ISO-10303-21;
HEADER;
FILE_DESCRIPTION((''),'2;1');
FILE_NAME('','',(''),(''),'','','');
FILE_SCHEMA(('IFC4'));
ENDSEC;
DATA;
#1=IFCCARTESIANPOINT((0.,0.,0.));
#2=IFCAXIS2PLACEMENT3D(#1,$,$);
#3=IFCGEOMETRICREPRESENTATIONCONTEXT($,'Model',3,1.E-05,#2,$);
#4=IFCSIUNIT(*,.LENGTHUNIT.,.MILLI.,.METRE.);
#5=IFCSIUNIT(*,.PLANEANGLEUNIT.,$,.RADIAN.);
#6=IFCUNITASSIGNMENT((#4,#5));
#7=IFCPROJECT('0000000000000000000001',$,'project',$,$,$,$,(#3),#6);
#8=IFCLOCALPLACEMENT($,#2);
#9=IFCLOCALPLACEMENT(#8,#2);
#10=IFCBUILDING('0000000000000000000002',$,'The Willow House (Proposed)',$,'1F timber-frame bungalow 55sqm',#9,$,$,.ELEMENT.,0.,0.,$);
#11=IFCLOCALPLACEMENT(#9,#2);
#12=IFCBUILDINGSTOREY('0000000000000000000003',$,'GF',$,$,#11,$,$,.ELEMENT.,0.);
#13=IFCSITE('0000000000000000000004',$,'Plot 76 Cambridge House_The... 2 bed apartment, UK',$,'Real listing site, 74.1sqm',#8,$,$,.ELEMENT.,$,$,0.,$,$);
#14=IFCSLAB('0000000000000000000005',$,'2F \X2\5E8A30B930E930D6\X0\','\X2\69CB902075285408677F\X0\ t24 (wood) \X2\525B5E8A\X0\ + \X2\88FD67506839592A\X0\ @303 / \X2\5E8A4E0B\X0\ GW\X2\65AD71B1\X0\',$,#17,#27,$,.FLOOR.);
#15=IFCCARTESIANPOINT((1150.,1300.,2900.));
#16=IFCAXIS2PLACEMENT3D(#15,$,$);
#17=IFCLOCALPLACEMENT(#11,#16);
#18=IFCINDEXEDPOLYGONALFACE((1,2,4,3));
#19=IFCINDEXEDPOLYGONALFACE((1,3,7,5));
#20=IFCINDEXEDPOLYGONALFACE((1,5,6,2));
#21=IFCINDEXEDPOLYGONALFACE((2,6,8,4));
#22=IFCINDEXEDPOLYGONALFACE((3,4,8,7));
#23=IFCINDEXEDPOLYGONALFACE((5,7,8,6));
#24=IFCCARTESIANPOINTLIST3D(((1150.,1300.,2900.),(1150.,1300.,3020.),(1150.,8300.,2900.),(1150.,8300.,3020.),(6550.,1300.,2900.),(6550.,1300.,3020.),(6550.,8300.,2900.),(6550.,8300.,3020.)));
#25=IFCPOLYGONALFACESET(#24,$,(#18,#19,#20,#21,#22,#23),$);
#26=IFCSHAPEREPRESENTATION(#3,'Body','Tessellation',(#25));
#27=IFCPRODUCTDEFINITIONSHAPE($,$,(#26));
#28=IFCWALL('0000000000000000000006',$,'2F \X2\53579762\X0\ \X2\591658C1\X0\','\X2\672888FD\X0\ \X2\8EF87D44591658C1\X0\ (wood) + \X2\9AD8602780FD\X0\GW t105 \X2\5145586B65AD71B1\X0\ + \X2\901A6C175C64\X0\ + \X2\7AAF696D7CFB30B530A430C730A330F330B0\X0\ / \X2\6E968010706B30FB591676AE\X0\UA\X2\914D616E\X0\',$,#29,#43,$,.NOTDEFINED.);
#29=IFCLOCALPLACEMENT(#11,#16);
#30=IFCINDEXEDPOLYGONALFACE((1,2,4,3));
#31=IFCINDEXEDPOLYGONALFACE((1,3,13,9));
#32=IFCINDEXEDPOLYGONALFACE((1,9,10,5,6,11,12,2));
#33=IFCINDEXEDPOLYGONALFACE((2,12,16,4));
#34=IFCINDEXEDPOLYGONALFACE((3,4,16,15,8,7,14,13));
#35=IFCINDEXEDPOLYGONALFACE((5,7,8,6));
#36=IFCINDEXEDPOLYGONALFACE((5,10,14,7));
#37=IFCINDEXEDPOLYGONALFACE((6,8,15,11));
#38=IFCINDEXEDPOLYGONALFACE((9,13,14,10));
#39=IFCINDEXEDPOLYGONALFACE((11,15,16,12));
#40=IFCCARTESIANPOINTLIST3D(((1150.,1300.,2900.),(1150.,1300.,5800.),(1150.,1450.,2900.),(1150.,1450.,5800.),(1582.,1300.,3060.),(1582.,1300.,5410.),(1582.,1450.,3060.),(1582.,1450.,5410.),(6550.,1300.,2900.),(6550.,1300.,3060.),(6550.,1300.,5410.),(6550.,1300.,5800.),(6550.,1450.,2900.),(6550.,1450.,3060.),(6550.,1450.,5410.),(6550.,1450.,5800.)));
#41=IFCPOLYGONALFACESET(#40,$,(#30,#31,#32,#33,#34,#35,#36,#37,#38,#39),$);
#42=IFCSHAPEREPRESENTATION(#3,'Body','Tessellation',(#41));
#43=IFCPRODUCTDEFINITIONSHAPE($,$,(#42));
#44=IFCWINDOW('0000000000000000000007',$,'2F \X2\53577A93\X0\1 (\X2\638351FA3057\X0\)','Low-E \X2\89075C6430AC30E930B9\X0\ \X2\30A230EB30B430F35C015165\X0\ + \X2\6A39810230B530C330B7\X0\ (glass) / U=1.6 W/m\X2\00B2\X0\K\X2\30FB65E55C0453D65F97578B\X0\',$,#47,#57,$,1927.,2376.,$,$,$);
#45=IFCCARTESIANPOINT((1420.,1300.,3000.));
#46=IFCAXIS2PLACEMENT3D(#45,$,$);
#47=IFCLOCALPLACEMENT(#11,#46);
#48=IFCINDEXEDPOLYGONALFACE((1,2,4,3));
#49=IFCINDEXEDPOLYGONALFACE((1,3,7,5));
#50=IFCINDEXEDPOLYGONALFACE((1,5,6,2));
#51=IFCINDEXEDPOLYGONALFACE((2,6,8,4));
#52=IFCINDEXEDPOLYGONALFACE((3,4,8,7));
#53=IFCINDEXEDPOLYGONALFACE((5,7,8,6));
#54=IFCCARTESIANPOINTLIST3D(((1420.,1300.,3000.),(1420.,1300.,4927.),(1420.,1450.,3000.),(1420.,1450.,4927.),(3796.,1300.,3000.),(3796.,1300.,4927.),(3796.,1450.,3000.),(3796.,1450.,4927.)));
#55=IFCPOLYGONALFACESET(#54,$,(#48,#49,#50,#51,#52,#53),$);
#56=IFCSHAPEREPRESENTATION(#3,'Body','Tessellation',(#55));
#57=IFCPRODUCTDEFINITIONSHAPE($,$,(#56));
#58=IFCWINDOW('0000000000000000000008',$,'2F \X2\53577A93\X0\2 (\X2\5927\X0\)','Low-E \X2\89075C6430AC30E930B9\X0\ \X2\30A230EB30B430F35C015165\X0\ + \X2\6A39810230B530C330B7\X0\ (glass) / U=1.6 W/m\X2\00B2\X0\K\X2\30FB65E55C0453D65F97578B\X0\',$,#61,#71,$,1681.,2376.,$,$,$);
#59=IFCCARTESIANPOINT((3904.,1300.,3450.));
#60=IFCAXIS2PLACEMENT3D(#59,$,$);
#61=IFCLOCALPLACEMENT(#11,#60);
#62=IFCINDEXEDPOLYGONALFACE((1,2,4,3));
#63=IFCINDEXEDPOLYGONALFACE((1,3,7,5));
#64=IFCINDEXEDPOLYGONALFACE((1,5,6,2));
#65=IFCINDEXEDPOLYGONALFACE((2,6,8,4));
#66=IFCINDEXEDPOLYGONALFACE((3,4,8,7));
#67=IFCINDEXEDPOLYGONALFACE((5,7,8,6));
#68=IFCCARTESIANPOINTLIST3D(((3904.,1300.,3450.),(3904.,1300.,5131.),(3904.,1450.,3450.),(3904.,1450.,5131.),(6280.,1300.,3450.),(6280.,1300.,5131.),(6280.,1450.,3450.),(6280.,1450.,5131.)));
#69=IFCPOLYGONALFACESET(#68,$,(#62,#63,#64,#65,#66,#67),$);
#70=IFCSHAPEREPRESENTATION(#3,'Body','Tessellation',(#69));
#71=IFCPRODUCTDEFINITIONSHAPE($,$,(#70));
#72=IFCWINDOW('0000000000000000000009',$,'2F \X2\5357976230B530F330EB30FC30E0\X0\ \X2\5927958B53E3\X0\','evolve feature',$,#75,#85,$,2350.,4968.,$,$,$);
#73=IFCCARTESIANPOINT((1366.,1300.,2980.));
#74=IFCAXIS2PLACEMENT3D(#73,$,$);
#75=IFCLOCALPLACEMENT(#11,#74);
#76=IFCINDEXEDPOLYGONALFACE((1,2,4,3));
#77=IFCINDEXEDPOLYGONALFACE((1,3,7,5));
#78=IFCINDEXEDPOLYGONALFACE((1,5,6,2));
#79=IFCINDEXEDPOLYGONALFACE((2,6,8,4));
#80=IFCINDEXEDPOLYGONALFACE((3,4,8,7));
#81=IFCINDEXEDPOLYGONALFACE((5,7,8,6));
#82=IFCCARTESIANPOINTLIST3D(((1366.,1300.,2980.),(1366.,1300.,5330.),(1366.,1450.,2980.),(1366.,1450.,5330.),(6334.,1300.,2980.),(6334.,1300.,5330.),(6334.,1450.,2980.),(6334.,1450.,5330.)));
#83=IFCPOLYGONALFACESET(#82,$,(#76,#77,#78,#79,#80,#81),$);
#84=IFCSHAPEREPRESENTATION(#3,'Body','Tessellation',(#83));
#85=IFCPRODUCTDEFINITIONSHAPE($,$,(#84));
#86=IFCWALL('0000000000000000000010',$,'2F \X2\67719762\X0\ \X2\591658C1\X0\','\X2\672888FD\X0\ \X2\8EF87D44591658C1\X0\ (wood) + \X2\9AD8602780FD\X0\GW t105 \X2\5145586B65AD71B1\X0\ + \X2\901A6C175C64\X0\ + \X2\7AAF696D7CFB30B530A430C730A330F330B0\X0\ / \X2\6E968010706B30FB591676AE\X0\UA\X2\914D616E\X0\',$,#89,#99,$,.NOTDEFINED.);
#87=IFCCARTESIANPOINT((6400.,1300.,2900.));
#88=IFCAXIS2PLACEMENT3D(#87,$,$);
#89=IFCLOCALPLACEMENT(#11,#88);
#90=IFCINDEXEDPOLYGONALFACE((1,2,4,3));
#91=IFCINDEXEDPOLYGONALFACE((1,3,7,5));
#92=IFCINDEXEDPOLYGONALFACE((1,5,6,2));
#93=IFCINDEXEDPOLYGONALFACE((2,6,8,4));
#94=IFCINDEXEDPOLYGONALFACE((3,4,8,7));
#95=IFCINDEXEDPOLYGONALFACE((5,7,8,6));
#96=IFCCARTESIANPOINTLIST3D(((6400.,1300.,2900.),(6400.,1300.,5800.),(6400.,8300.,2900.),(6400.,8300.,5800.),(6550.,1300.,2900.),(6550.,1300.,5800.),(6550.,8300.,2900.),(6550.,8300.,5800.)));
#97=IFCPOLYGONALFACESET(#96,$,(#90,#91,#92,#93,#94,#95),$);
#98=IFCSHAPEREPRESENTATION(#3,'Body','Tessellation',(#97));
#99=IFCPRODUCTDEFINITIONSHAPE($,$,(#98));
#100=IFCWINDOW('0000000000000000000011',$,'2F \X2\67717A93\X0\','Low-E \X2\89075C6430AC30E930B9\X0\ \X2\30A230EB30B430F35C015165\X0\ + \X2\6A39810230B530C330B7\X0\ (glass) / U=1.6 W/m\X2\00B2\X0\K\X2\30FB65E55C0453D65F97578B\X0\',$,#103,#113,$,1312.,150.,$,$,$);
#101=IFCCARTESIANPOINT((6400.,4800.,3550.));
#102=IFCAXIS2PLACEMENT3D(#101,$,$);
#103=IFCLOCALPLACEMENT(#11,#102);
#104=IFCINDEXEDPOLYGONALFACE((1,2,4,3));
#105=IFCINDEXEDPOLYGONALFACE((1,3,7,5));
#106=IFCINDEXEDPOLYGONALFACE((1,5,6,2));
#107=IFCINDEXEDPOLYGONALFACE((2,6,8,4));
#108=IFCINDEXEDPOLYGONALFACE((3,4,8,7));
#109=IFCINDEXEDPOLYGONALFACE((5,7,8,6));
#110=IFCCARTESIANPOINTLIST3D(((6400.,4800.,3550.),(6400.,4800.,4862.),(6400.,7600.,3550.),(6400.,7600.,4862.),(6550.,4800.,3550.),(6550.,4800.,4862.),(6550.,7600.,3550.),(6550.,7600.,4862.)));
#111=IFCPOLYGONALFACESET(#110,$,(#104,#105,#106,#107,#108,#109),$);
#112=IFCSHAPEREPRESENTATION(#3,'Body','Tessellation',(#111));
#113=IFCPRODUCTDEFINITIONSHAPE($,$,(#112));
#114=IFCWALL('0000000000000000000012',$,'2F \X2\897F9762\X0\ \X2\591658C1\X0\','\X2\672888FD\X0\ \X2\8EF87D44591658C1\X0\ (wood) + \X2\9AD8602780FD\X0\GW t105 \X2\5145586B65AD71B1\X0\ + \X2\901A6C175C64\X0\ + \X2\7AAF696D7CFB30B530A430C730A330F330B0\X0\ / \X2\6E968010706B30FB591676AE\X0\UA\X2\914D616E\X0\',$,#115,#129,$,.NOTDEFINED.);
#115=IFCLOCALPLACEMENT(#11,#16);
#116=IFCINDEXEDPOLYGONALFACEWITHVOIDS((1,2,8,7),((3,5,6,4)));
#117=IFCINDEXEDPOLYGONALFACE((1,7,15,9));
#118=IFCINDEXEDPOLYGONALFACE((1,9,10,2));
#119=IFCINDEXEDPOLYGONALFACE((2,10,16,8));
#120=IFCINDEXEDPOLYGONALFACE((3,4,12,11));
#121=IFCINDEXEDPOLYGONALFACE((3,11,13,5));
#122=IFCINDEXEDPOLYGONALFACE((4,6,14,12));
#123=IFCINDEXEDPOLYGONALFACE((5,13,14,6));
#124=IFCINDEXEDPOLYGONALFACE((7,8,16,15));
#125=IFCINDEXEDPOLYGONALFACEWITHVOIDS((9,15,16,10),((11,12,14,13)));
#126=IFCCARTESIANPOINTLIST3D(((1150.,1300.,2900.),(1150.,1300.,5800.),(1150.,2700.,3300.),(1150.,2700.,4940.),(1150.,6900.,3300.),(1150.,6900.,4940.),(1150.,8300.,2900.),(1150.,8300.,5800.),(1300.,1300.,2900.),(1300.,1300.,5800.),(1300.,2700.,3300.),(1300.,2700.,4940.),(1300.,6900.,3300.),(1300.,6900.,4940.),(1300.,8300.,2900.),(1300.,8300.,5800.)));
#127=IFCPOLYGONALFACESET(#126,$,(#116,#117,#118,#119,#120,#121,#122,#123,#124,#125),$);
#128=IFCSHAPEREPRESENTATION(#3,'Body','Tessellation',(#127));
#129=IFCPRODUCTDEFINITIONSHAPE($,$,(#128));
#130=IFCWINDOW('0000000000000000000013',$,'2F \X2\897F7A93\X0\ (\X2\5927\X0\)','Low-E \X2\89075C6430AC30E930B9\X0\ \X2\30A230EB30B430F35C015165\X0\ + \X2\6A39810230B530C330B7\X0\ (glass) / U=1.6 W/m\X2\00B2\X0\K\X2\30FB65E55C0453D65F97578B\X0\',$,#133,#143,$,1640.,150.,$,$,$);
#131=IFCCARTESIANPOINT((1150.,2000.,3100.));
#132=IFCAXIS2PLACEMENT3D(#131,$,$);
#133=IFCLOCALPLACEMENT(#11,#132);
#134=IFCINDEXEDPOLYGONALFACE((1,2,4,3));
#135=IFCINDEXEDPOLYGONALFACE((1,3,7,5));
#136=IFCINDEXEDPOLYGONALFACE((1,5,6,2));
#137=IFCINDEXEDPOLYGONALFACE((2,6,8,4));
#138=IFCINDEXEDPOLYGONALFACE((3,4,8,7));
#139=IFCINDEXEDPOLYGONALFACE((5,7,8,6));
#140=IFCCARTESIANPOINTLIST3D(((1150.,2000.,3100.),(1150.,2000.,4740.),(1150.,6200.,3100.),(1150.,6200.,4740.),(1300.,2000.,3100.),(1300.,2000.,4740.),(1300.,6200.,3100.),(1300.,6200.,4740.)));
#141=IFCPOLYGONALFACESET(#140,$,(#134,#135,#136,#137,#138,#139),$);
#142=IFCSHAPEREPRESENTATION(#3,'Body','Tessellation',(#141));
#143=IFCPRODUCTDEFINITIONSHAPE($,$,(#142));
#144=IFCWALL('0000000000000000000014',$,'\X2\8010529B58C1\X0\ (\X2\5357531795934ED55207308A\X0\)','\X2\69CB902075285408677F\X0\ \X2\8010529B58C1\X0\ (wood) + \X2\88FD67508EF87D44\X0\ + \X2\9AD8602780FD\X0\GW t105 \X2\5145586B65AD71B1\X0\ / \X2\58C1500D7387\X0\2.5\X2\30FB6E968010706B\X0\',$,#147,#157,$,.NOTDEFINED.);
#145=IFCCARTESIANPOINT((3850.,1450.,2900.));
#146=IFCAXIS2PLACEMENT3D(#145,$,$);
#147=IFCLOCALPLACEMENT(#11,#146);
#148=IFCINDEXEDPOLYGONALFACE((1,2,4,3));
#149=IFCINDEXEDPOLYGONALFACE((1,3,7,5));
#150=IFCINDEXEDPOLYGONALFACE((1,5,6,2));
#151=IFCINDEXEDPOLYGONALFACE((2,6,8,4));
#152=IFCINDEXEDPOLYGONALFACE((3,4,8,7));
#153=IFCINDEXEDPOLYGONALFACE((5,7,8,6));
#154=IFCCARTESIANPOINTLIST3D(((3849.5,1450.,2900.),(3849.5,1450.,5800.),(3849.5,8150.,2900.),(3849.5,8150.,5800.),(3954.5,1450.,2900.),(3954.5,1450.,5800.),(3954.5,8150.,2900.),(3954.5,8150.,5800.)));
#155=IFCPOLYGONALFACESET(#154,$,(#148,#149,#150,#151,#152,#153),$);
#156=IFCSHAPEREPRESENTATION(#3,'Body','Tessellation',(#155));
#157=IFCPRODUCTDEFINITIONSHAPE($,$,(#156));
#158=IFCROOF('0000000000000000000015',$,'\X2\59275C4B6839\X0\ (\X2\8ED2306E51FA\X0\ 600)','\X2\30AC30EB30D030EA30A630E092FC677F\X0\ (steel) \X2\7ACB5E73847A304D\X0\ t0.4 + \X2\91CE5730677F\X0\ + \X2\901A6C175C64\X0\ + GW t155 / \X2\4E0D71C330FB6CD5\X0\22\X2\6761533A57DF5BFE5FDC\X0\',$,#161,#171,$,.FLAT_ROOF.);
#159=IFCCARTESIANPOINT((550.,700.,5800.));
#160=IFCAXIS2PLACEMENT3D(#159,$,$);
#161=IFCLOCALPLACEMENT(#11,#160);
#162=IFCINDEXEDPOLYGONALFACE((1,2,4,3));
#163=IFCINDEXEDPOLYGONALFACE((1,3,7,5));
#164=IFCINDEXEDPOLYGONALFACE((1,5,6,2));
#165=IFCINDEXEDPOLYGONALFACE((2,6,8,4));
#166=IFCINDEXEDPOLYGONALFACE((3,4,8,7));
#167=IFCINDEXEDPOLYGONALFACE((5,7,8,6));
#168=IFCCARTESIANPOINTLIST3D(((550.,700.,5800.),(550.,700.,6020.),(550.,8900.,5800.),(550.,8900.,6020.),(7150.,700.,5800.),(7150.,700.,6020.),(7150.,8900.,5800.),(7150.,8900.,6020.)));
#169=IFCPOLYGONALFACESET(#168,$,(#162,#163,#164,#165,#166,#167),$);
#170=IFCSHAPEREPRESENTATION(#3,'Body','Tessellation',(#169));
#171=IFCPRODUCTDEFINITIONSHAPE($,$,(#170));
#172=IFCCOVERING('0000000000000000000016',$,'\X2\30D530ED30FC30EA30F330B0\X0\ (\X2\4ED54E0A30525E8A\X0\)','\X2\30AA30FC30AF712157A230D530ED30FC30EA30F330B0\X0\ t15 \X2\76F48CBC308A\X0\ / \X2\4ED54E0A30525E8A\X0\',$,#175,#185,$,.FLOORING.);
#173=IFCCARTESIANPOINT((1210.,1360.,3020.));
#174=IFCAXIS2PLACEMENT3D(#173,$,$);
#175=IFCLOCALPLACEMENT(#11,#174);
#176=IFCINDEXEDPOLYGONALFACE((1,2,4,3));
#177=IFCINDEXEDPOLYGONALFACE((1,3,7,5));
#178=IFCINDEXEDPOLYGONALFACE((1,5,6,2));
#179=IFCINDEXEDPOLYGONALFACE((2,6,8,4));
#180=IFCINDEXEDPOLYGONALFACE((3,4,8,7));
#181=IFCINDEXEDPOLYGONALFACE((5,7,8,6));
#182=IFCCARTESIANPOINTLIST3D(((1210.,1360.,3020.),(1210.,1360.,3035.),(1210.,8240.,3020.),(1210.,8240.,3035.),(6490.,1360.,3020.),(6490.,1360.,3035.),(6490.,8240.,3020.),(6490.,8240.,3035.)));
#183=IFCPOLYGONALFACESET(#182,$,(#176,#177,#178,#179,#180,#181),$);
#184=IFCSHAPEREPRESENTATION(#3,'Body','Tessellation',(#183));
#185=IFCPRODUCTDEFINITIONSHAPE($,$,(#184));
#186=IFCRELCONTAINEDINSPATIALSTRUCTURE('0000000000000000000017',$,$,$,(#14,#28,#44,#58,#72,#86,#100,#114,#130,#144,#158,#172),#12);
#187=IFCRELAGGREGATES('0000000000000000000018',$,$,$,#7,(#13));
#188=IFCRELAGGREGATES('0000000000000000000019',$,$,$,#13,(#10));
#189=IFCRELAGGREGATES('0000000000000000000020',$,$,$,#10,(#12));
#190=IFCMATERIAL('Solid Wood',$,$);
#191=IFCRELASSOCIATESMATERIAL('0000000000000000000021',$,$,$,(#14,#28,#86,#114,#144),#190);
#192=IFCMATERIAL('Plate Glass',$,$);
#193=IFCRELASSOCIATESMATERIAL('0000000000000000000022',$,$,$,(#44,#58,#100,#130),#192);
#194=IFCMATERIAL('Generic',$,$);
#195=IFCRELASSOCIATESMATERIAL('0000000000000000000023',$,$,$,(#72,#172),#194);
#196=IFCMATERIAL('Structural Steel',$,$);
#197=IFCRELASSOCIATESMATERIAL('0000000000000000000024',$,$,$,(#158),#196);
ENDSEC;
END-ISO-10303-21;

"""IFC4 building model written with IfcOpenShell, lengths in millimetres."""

from ifc_helpers import new_model, si_unit, frame, frame_2d, origin, place, context, project, spatial, rectangle, extrude, material, element, fill, save


model = new_model("IFC4")

# Units and contexts
model_context = context("Model", 3, precision=1e-05, world=origin())
ifc_project = project(units=[si_unit("LENGTHUNIT", "METRE", prefix="MILLI"), si_unit("PLANEANGLEUNIT", "RADIAN")], contexts=[model_context])

# Site, building, storey
site_placement = place(None, origin())
site = spatial("IfcSite", under=ifc_project, at=site_placement, Name="Plot 76 Cambridge House_The... 2 bed apartment, UK", ObjectType="Real listing site, 74.1sqm", CompositionType="ELEMENT", RefElevation=0.0)
building_placement = place(site_placement, origin())
building = spatial("IfcBuilding", under=site, at=building_placement, Name="The Willow House (Proposed)", ObjectType="1F timber-frame bungalow 55sqm", CompositionType="ELEMENT", ElevationOfRefHeight=0.0, ElevationOfTerrain=0.0)
storey_placement = place(building_placement, origin())
storey = spatial("IfcBuildingStorey", under=building, at=storey_placement, Name="GF", CompositionType="ELEMENT", Elevation=0.0)

# Slab
ifc_material_1 = material(Name="Solid Wood")
slab_placement = place(storey_placement, frame((1150.0, 1300.0, 2900.0)))
element("IfcSlab", 1, at=slab_placement, inside=storey, material=ifc_material_1, Name="2F 床スラブ", Description="構造用合板 t24 (wood) 剛床 + 製材根太 @303 / 床下 GW断熱", PredefinedType="FLOOR", context=model_context, shape_type="SweptSolid", body=[
    extrude(rectangle(XDim=5400.0, YDim=7000.0, at=frame_2d((2700.0, 3500.0))), frame((1150.0, 1300.0, 2900.0)), (0.0, 0.0, 1.0), 120.0),
])

# Wall, openings, windows
wall_1_placement = place(storey_placement, frame((1150.0, 1300.0, 2900.0)))
wall_1 = element("IfcWall", 2, at=wall_1_placement, inside=storey, material=ifc_material_1, Name="2F 南面 外壁", Description="木製 軸組外壁 (wood) + 高性能GW t105 充填断熱 + 通気層 + 窯業系サイディング / 準耐火・外皮UA配慮", PredefinedType="NOTDEFINED", context=model_context, shape_type="SweptSolid", body=[
    extrude(rectangle(XDim=5400.0, YDim=150.0, at=frame_2d((2700.0, 75.0))), frame((1150.0, 1300.0, 2900.0)), (0.0, 0.0, 1.0), 2900.0),
])
opening_1_placement = place(storey_placement, frame((1420.0, 1300.0, 3000.0)))
opening_1 = element("IfcOpeningElement", 3, at=opening_1_placement, cuts=wall_1, PredefinedType="NOTDEFINED", context=model_context, shape_type="SweptSolid", body=[
    extrude(rectangle(XDim=2376.0, YDim=150.0, at=frame_2d((1188.0, 75.0))), frame((1420.0, 1300.0, 3000.0)), (0.0, 0.0, 1.0), 1927.0),
])
opening_2_placement = place(storey_placement, frame((3904.0, 1300.0, 3450.0)))
opening_2 = element("IfcOpeningElement", 4, at=opening_2_placement, cuts=wall_1, PredefinedType="NOTDEFINED", context=model_context, shape_type="SweptSolid", body=[
    extrude(rectangle(XDim=2376.0, YDim=150.0, at=frame_2d((1188.0, 75.0))), frame((3904.0, 1300.0, 3450.0)), (0.0, 0.0, 1.0), 1681.0),
])
opening_3_placement = place(storey_placement, frame((1366.0, 1300.0, 2980.0)))
opening_3 = element("IfcOpeningElement", 5, at=opening_3_placement, cuts=wall_1, PredefinedType="NOTDEFINED", context=model_context, shape_type="SweptSolid", body=[
    extrude(rectangle(XDim=4968.0, YDim=150.0, at=frame_2d((2484.0, 75.0))), frame((1366.0, 1300.0, 2980.0)), (0.0, 0.0, 1.0), 2350.0),
])
ifc_material_2 = material(Name="Plate Glass")
window_1_placement = place(storey_placement, frame((1420.0, 1300.0, 3000.0)))
window_1 = element("IfcWindow", 6, at=window_1_placement, inside=storey, material=ifc_material_2, Name="2F 南窓1 (掃出し)", Description="Low-E 複層ガラス アルゴン封入 + 樹脂サッシ (glass) / U=1.6 W/m²K・日射取得型", OverallHeight=1927.0, OverallWidth=2376.0, context=model_context, shape_type="SweptSolid", body=[
    extrude(rectangle(XDim=2376.0, YDim=150.0, at=frame_2d((1188.0, 75.0))), frame((1420.0, 1300.0, 3000.0)), (0.0, 0.0, 1.0), 1927.0),
])
fill(opening_1, window_1)
window_2_placement = place(storey_placement, frame((3904.0, 1300.0, 3450.0)))
window_2 = element("IfcWindow", 7, at=window_2_placement, inside=storey, material=ifc_material_2, Name="2F 南窓2 (大)", Description="Low-E 複層ガラス アルゴン封入 + 樹脂サッシ (glass) / U=1.6 W/m²K・日射取得型", OverallHeight=1681.0, OverallWidth=2376.0, context=model_context, shape_type="SweptSolid", body=[
    extrude(rectangle(XDim=2376.0, YDim=150.0, at=frame_2d((1188.0, 75.0))), frame((3904.0, 1300.0, 3450.0)), (0.0, 0.0, 1.0), 1681.0),
])
fill(opening_2, window_2)
ifc_material_3 = material(Name="Generic")
window_3_placement = place(storey_placement, frame((1366.0, 1300.0, 2980.0)))
window_3 = element("IfcWindow", 8, at=window_3_placement, inside=storey, material=ifc_material_3, Name="2F 南面サンルーム 大開口", Description="evolve feature", OverallHeight=2350.0, OverallWidth=4968.0, context=model_context, shape_type="SweptSolid", body=[
    extrude(rectangle(XDim=4968.0, YDim=150.0, at=frame_2d((2484.0, 75.0))), frame((1366.0, 1300.0, 2980.0)), (0.0, 0.0, 1.0), 2350.0),
])
fill(opening_3, window_3)

# Walls, openings, windows
wall_2_placement = place(storey_placement, frame((6400.0, 1300.0, 2900.0)))
wall_2 = element("IfcWall", 9, at=wall_2_placement, inside=storey, material=ifc_material_1, Name="2F 東面 外壁", Description="木製 軸組外壁 (wood) + 高性能GW t105 充填断熱 + 通気層 + 窯業系サイディング / 準耐火・外皮UA配慮", PredefinedType="NOTDEFINED", context=model_context, shape_type="SweptSolid", body=[
    extrude(rectangle(XDim=150.0, YDim=7000.0, at=frame_2d((75.0, 3500.0))), frame((6400.0, 1300.0, 2900.0)), (0.0, 0.0, 1.0), 2900.0),
])
opening_4_placement = place(storey_placement, frame((6400.0, 4800.0, 3550.0)))
opening_4 = element("IfcOpeningElement", 10, at=opening_4_placement, cuts=wall_2, PredefinedType="NOTDEFINED", context=model_context, shape_type="SweptSolid", body=[
    extrude(rectangle(XDim=150.0, YDim=2800.0, at=frame_2d((75.0, 1400.0))), frame((6400.0, 4800.0, 3550.0)), (0.0, 0.0, 1.0), 1312.0),
])
window_4_placement = place(storey_placement, frame((6400.0, 4800.0, 3550.0)))
window_4 = element("IfcWindow", 11, at=window_4_placement, inside=storey, material=ifc_material_2, Name="2F 東窓", Description="Low-E 複層ガラス アルゴン封入 + 樹脂サッシ (glass) / U=1.6 W/m²K・日射取得型", OverallHeight=1312.0, OverallWidth=150.0, context=model_context, shape_type="SweptSolid", body=[
    extrude(rectangle(XDim=150.0, YDim=2800.0, at=frame_2d((75.0, 1400.0))), frame((6400.0, 4800.0, 3550.0)), (0.0, 0.0, 1.0), 1312.0),
])
fill(opening_4, window_4)
wall_3_placement = place(storey_placement, frame((1150.0, 1300.0, 2900.0)))
wall_3 = element("IfcWall", 12, at=wall_3_placement, inside=storey, material=ifc_material_1, Name="2F 西面 外壁", Description="木製 軸組外壁 (wood) + 高性能GW t105 充填断熱 + 通気層 + 窯業系サイディング / 準耐火・外皮UA配慮", PredefinedType="NOTDEFINED", context=model_context, shape_type="SweptSolid", body=[
    extrude(rectangle(XDim=150.0, YDim=7000.0, at=frame_2d((75.0, 3500.0))), frame((1150.0, 1300.0, 2900.0)), (0.0, 0.0, 1.0), 2900.0),
])
opening_5_placement = place(storey_placement, frame((1150.0, 2000.0, 3100.0)))
opening_5 = element("IfcOpeningElement", 13, at=opening_5_placement, cuts=wall_3, PredefinedType="NOTDEFINED", context=model_context, shape_type="SweptSolid", body=[
    extrude(rectangle(XDim=150.0, YDim=4200.0, at=frame_2d((75.0, 2100.0))), frame((1150.0, 2000.0, 3100.0)), (0.0, 0.0, 1.0), 1640.0),
])
window_5_placement = place(storey_placement, frame((1150.0, 2000.0, 3100.0)))
window_5 = element("IfcWindow", 14, at=window_5_placement, inside=storey, material=ifc_material_2, Name="2F 西窓 (大)", Description="Low-E 複層ガラス アルゴン封入 + 樹脂サッシ (glass) / U=1.6 W/m²K・日射取得型", OverallHeight=1640.0, OverallWidth=150.0, context=model_context, shape_type="SweptSolid", body=[
    extrude(rectangle(XDim=150.0, YDim=4200.0, at=frame_2d((75.0, 2100.0))), frame((1150.0, 2000.0, 3100.0)), (0.0, 0.0, 1.0), 1640.0),
])
fill(opening_5, window_5)

# Wall
wall_4_placement = place(storey_placement, frame((3850.0, 1450.0, 2900.0)))
element("IfcWall", 15, at=wall_4_placement, inside=storey, material=ifc_material_1, Name="耐力壁 (南北間仕切り)", Description="構造用合板 耐力壁 (wood) + 製材軸組 + 高性能GW t105 充填断熱 / 壁倍率2.5・準耐火", PredefinedType="NOTDEFINED", context=model_context, shape_type="SweptSolid", body=[
    extrude(rectangle(XDim=105.0, YDim=6700.0, at=frame_2d((52.0, 3350.0))), frame((3850.0, 1450.0, 2900.0)), (0.0, 0.0, 1.0), 2900.0),
])

# Roof
ifc_material_4 = material(Name="Structural Steel")
roof_placement = place(storey_placement, frame((550.0, 700.0, 5800.0)))
element("IfcRoof", 16, at=roof_placement, inside=storey, material=ifc_material_4, Name="大屋根 (軒の出 600)", Description="ガルバリウム鋼板 (steel) 立平葺き t0.4 + 野地板 + 通気層 + GW t155 / 不燃・法22条区域対応", PredefinedType="FLAT_ROOF", context=model_context, shape_type="SweptSolid", body=[
    extrude(rectangle(XDim=6600.0, YDim=8200.0, at=frame_2d((3300.0, 4100.0))), frame((550.0, 700.0, 5800.0)), (0.0, 0.0, 1.0), 220.0),
])

# Covering
covering_placement = place(storey_placement, frame((1210.0, 1360.0, 3020.0)))
element("IfcCovering", 17, at=covering_placement, inside=storey, material=ifc_material_3, Name="フローリング (仕上げ床)", Description="オーク無垢フローリング t15 直貼り / 仕上げ床", PredefinedType="FLOORING", context=model_context, shape_type="SweptSolid", body=[
    extrude(rectangle(XDim=5280.0, YDim=6880.0, at=frame_2d((2640.0, 3440.0))), frame((1210.0, 1360.0, 3020.0)), (0.0, 0.0, 1.0), 15.0),
])

save(model, "model.ifc")
